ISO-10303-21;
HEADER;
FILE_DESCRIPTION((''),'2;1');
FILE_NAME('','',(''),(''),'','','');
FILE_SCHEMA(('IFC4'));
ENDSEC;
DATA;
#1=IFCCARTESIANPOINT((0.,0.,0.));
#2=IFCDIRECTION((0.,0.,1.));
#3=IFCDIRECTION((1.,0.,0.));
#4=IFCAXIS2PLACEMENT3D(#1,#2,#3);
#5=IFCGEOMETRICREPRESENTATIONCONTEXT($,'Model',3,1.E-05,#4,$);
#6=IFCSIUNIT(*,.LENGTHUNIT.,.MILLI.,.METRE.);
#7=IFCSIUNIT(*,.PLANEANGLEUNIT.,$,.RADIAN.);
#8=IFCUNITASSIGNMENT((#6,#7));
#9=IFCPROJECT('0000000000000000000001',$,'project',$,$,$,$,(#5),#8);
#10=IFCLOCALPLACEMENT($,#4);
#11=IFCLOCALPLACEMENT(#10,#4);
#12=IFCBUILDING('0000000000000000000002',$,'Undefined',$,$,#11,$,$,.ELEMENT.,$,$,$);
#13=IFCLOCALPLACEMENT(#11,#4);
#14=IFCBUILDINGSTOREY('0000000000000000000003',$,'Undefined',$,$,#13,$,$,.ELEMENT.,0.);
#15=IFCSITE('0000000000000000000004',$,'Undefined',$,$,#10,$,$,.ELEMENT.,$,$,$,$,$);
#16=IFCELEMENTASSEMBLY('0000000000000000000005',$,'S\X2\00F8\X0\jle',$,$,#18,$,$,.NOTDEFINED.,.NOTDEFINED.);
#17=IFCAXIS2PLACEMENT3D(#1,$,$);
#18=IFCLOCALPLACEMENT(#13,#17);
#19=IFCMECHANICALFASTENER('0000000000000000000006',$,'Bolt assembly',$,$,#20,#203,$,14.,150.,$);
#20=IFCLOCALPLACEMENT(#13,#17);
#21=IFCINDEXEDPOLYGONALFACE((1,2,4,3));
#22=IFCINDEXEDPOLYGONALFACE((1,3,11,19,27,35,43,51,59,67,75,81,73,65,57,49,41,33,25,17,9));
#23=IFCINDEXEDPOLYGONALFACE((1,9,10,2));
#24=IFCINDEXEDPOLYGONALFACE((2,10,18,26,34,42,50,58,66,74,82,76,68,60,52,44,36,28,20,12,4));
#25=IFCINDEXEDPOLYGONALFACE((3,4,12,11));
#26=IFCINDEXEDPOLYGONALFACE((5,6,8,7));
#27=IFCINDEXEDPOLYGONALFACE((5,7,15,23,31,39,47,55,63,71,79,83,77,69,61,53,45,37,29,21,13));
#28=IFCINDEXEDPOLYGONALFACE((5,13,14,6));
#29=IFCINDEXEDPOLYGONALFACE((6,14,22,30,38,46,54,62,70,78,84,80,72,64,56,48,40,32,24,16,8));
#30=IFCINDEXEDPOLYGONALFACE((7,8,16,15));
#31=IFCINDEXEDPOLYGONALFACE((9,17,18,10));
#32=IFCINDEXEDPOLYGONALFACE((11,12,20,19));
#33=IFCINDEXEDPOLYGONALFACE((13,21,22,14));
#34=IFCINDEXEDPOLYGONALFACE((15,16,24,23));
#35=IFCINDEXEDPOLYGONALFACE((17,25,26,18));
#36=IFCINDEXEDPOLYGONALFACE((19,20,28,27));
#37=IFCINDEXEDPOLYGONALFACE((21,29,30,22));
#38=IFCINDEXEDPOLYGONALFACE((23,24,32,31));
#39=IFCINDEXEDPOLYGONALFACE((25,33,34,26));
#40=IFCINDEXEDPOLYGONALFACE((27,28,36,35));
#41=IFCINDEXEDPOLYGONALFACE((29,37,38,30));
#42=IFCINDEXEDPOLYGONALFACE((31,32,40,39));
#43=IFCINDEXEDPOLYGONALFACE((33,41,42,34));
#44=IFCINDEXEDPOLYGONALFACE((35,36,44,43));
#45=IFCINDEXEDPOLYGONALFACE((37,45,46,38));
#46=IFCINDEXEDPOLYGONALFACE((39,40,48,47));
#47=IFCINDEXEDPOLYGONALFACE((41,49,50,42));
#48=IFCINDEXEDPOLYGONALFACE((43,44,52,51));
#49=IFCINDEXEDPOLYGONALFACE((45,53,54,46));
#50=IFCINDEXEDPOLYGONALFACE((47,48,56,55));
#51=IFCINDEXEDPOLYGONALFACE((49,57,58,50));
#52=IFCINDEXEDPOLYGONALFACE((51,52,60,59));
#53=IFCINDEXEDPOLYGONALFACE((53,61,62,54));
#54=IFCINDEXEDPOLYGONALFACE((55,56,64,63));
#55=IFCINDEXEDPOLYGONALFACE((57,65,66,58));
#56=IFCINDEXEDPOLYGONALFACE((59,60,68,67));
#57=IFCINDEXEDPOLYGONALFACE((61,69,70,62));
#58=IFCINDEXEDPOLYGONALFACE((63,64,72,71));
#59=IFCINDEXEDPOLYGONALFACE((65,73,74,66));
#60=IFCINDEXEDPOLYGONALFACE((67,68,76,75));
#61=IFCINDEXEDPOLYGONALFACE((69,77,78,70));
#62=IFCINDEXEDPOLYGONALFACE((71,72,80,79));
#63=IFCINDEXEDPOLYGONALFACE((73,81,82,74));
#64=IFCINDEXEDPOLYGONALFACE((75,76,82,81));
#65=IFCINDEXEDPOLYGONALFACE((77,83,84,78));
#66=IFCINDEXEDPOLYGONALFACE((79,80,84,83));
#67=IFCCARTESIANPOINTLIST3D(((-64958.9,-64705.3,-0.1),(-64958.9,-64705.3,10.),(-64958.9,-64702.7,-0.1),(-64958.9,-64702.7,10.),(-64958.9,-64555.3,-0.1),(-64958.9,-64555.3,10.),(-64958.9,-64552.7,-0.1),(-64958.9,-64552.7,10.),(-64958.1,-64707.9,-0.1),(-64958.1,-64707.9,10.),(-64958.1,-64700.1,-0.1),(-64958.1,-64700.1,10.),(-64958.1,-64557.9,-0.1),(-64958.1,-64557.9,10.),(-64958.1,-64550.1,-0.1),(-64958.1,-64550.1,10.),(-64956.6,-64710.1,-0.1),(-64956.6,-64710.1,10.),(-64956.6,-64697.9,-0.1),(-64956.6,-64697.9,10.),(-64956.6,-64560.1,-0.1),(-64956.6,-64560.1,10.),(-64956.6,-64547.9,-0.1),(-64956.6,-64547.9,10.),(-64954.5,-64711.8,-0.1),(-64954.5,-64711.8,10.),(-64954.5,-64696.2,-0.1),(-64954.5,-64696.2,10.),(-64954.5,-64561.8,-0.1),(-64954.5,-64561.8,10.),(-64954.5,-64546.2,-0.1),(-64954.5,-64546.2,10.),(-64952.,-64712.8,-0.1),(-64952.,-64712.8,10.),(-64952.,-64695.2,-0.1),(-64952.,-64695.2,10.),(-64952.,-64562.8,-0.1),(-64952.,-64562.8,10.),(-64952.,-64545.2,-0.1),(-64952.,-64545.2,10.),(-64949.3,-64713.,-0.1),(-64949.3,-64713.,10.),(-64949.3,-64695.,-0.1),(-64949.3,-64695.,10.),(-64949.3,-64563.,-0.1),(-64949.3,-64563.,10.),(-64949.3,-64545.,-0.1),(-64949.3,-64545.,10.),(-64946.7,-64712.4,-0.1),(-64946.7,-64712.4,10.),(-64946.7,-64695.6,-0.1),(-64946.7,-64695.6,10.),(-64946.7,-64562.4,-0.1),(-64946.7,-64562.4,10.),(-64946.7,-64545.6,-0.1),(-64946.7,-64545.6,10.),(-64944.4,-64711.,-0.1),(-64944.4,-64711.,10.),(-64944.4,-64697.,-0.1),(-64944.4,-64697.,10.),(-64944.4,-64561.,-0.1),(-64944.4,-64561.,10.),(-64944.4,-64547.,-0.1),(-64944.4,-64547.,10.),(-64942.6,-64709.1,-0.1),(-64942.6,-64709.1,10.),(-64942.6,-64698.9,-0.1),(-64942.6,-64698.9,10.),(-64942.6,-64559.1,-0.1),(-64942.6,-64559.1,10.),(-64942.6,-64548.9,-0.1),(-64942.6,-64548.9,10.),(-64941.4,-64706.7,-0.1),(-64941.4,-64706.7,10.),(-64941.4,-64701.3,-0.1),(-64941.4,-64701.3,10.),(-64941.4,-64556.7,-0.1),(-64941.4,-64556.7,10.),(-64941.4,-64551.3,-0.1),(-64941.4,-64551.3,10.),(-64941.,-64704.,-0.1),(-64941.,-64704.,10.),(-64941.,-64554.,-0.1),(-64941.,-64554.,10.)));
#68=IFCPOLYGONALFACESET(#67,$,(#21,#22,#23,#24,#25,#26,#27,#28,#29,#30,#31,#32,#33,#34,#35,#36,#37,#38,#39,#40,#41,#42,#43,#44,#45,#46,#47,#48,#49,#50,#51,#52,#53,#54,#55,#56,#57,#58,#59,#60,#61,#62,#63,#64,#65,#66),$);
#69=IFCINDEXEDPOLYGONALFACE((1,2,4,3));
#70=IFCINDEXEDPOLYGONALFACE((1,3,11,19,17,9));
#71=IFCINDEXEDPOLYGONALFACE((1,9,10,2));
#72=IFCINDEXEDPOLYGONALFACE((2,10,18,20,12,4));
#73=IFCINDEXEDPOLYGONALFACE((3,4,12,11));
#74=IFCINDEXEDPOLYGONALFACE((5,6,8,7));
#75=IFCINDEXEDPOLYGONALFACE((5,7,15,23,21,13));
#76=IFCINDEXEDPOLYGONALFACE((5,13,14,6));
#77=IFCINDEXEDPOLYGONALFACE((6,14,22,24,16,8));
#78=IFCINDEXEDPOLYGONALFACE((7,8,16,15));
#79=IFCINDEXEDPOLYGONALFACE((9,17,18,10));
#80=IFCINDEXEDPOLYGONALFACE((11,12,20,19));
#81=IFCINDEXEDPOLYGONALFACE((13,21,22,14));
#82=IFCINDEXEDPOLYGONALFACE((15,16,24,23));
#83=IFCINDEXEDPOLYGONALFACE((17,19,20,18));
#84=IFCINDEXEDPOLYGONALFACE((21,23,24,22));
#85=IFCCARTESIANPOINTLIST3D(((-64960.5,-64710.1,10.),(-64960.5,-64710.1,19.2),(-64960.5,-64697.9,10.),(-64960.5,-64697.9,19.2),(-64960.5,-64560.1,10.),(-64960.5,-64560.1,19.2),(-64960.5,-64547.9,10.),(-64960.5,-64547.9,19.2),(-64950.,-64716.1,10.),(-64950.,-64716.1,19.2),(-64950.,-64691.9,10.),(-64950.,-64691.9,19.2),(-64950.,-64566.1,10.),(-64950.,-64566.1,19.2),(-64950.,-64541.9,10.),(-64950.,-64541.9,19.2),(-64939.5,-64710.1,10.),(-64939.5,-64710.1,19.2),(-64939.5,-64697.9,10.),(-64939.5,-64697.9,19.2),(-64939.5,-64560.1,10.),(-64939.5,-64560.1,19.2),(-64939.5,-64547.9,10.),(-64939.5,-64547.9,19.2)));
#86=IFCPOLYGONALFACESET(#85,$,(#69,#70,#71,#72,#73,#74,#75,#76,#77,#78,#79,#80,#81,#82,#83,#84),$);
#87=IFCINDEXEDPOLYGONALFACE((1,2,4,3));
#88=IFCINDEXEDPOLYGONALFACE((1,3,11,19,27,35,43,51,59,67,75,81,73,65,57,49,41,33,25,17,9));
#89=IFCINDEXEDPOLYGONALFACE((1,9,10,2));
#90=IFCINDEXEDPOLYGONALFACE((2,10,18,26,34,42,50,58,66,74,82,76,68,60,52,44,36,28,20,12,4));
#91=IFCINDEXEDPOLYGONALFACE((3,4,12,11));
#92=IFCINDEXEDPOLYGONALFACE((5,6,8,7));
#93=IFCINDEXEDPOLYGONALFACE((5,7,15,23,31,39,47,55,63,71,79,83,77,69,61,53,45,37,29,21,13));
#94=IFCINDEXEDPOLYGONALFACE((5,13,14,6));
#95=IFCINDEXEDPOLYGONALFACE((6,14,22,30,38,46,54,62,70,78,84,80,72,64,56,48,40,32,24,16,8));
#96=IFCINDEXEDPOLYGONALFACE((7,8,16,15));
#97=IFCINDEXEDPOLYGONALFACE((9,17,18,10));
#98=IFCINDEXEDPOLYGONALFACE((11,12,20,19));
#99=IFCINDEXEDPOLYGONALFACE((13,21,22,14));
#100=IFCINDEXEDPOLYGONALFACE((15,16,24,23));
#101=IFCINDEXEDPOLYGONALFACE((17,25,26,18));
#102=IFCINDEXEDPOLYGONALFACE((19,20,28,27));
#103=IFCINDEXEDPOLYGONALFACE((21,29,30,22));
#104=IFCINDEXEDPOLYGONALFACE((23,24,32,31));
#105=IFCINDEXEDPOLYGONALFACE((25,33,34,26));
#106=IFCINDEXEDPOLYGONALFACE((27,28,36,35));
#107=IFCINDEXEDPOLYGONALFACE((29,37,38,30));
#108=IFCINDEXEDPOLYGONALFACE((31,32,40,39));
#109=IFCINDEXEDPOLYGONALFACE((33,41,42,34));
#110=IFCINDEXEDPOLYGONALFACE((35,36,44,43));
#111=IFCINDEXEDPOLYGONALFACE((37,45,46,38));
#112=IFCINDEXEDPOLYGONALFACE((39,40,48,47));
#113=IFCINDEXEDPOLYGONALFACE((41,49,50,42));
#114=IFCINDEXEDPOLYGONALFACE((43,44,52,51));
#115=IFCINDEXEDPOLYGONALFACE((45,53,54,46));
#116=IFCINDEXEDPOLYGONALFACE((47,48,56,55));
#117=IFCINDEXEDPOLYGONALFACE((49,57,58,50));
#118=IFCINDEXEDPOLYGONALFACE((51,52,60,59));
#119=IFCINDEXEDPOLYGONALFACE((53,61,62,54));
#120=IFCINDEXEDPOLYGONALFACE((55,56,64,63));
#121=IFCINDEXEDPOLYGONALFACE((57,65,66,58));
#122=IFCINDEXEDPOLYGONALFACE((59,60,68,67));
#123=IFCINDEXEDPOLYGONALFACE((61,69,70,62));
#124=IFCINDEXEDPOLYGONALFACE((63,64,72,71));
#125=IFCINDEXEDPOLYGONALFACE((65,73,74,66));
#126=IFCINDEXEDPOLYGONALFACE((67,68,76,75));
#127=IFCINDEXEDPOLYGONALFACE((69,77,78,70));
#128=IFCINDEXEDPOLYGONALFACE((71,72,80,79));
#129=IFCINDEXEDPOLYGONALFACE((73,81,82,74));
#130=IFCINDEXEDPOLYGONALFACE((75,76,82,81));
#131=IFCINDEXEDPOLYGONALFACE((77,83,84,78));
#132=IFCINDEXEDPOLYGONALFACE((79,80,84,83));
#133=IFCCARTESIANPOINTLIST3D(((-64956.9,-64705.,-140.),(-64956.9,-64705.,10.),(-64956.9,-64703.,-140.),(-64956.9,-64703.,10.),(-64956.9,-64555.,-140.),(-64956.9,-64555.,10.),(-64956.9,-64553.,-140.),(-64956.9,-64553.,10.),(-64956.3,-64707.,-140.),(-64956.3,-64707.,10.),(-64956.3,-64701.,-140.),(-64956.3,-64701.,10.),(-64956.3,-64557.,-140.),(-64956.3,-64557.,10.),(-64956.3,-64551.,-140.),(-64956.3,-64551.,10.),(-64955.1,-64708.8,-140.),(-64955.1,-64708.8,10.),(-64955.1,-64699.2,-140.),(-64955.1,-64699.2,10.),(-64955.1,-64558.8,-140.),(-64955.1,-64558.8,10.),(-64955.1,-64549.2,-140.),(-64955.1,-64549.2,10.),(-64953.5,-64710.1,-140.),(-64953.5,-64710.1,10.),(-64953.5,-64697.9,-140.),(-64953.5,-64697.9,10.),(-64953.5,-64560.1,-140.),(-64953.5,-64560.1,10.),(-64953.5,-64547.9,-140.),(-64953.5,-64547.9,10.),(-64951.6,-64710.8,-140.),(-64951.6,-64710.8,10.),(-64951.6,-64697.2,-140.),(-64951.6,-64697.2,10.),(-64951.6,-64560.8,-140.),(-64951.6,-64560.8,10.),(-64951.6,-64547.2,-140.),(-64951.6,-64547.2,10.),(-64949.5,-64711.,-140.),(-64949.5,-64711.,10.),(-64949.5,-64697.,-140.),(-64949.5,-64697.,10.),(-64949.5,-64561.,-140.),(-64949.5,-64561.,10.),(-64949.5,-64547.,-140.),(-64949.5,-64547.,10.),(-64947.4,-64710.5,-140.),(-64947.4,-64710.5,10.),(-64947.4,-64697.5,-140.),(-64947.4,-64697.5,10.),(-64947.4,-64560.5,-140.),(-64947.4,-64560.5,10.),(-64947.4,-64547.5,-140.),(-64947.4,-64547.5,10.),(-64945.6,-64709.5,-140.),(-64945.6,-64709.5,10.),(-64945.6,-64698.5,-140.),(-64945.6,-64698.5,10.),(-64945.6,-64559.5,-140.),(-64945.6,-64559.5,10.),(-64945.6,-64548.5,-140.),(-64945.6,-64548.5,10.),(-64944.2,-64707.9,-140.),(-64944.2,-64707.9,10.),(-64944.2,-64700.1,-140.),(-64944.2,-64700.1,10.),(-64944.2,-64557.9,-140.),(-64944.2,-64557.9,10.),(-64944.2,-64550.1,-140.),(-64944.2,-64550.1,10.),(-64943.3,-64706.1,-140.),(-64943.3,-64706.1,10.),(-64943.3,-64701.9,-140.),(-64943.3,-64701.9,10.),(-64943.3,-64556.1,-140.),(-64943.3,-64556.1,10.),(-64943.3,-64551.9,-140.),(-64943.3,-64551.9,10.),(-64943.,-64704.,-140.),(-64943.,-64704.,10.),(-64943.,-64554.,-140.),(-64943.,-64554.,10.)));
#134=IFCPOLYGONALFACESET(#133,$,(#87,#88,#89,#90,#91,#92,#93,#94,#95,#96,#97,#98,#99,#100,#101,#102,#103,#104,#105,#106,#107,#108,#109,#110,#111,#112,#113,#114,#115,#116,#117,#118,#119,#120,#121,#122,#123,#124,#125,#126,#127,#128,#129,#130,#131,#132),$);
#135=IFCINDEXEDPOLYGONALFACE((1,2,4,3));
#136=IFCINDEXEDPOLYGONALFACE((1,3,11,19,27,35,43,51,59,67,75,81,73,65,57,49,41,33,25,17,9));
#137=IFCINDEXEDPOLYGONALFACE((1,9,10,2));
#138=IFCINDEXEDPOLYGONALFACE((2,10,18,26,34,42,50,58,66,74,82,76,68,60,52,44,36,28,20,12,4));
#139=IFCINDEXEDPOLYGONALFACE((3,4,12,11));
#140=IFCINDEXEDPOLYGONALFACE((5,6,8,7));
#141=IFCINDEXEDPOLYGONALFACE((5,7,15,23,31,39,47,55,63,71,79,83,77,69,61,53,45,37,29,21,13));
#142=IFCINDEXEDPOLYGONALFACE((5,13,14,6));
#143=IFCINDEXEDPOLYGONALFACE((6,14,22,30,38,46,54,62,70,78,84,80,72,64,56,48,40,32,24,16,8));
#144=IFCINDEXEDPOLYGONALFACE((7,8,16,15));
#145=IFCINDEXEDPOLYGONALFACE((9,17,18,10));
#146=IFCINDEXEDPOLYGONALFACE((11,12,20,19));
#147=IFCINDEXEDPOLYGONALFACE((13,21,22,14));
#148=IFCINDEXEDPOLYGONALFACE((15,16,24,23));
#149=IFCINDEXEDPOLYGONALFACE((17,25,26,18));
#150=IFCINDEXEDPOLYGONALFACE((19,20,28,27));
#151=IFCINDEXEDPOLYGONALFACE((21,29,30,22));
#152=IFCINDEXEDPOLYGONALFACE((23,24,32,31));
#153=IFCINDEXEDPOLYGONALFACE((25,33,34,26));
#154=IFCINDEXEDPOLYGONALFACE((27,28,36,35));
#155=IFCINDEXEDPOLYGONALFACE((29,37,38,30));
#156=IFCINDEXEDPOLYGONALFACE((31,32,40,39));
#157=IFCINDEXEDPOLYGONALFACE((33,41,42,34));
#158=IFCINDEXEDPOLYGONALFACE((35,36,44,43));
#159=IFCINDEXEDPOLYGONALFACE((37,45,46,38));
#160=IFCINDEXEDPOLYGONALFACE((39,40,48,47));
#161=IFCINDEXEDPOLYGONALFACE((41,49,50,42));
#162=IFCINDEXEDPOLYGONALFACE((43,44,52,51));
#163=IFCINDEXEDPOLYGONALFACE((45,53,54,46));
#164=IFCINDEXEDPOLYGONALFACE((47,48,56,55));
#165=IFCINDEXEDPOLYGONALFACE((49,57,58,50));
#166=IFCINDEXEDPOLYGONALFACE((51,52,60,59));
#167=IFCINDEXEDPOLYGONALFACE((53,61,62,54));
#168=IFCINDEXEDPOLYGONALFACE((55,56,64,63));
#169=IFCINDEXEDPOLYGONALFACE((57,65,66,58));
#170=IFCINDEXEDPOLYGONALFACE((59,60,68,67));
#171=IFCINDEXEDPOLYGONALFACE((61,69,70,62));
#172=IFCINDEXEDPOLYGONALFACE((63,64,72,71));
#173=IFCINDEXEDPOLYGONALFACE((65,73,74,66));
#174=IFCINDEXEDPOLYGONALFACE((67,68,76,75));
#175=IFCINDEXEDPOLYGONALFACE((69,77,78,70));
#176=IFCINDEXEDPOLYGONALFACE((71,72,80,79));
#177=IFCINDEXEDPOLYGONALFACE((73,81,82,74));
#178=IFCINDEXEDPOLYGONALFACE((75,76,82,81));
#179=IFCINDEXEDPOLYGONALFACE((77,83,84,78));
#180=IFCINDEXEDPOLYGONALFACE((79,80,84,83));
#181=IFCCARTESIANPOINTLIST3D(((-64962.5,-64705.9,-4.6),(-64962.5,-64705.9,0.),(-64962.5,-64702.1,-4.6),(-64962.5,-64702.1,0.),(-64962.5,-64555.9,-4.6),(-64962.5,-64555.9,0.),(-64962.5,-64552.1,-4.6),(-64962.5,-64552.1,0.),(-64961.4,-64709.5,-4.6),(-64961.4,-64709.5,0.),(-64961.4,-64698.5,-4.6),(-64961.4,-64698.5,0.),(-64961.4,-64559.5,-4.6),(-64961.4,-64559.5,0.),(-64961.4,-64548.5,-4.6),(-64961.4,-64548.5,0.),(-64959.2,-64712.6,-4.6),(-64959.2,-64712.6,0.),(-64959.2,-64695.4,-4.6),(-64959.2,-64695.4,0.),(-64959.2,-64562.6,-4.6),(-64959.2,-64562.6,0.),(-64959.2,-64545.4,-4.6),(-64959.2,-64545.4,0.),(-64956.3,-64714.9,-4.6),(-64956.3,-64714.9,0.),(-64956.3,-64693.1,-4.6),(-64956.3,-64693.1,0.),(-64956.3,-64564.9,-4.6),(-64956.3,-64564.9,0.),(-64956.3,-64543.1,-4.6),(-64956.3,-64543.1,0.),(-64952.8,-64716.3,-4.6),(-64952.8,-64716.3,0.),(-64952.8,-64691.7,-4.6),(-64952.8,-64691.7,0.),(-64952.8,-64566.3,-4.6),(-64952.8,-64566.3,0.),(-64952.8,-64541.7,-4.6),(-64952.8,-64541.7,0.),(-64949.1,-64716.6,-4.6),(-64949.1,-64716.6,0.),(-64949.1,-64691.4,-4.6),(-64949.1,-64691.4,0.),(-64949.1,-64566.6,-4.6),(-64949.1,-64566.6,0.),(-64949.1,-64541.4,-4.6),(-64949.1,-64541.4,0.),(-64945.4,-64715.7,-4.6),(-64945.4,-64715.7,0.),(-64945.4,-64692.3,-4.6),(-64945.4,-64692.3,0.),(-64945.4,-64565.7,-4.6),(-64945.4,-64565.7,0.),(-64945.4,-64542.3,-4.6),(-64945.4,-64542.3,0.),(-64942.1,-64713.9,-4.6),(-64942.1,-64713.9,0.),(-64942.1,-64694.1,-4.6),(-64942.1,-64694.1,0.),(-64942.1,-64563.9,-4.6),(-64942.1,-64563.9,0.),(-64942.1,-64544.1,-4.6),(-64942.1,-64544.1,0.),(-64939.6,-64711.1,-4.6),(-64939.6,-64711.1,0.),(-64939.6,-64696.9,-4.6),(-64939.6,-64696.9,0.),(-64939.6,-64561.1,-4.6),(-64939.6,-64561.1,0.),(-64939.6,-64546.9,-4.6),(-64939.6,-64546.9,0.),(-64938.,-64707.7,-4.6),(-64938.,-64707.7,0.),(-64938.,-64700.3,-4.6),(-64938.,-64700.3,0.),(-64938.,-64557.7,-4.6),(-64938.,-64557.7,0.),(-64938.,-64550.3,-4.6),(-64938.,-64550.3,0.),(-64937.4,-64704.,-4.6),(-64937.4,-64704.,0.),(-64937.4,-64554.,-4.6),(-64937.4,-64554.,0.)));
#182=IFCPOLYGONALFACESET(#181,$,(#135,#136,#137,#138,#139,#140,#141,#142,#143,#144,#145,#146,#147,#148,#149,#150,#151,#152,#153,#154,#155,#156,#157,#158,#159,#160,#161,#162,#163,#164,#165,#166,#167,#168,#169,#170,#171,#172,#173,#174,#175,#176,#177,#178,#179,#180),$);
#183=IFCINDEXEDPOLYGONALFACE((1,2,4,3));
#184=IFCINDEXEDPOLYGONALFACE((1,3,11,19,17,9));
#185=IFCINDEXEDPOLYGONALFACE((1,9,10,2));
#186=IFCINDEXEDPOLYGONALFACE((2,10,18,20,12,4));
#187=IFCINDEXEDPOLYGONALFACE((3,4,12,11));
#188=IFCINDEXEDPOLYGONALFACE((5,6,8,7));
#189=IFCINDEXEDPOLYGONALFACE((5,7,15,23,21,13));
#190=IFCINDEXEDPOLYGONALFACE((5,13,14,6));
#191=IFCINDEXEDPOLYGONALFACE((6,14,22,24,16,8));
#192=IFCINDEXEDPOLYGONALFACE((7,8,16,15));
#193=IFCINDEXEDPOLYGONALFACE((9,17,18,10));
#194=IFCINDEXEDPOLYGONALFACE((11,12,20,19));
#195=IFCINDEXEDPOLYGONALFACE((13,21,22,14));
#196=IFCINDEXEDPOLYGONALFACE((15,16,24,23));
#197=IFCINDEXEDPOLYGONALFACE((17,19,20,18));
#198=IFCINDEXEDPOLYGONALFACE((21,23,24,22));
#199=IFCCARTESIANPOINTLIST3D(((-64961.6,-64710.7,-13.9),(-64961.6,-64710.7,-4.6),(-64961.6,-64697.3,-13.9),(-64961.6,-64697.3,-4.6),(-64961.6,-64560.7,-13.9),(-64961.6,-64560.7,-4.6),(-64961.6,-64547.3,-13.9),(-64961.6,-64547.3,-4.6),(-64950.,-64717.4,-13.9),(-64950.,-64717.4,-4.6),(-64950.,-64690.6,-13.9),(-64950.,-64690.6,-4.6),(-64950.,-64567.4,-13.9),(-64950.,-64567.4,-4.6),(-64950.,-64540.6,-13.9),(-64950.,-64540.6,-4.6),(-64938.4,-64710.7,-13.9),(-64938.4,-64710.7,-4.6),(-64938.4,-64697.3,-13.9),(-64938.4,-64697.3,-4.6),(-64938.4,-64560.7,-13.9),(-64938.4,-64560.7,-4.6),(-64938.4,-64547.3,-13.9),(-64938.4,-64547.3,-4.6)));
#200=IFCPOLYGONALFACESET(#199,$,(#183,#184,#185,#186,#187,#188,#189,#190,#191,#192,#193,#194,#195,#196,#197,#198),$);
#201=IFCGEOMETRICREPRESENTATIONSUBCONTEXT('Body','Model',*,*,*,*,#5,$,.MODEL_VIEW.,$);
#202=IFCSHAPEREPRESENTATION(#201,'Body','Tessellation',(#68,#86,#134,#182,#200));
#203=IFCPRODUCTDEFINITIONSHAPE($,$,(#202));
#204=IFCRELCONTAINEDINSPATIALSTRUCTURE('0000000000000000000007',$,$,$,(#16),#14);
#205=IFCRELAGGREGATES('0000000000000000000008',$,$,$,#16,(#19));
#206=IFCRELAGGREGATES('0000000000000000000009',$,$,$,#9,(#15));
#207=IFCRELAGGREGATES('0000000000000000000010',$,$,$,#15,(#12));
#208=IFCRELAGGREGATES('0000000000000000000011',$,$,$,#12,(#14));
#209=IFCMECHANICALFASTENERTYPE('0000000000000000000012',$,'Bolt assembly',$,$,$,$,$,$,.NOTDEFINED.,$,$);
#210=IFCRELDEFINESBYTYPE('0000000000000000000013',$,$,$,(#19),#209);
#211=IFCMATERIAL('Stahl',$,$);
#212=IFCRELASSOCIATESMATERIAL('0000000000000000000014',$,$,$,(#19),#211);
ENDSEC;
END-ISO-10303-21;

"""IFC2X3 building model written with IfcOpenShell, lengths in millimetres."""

from ifc_helpers import new_model, si_unit, frame, origin_with_axes, origin_2d_with_axis, place, context, subcontext, project, spatial, polyline, circle, outline, extrude, source, transform, mapped, material, type_object, element, aggregate, save


model = new_model("IFC2X3")

# Units and contexts
model_context = context("Model", 3, precision=1e-05, world=origin_with_axes())
body_context = subcontext(model_context, "Body", "Model", "MODEL_VIEW")
ifc_project = project(units=[si_unit("LENGTHUNIT", "METRE", prefix="MILLI"), si_unit("PLANEANGLEUNIT", "RADIAN")], contexts=[model_context])

# Site, building, storey
site_placement = place(None, origin_with_axes())
site = spatial("IfcSite", under=ifc_project, at=site_placement, Name="Undefined", CompositionType="ELEMENT")
building_placement = place(site_placement, origin_with_axes())
building = spatial("IfcBuilding", under=site, at=building_placement, Name="Undefined", CompositionType="ELEMENT")
storey_placement = place(building_placement, origin_with_axes())
storey = spatial("IfcBuildingStorey", under=building, at=storey_placement, Name="Undefined", CompositionType="ELEMENT", Elevation=0.0)

# Element assembly
assembly_1_placement = place(storey_placement, origin_with_axes())
assembly_1 = element("IfcElementAssembly", 1, at=assembly_1_placement, inside=storey, Name="Søjle", AssemblyPlace="NOTDEFINED", PredefinedType="NOTDEFINED")

# Mechanical fastener
mechanical_fastener_type = type_object("IfcMechanicalFastenerType", Name="Bolt assembly")
ifc_material_1 = material(Name="Stahl")
shared_shape_1 = source(origin_with_axes(), body_context, "Body", "SweptSolid", [
    extrude(circle(Radius=9.0, at=origin_2d_with_axis()), frame((0.0, 0.0, 0.0), z_axis=(0.0, 1.0, 0.0), x_axis=(1.0, 0.0, 0.0)), (0.0, 0.0, 1.0), 10.1),
    extrude(outline(polyline([(10.5, -6.1), (10.5, 6.1), (0.0, 12.1), (-10.5, 6.1), (-10.5, -6.1), (0.0, -12.1), (10.5, -6.1)])), frame((0.0, -9.2, 0.0), z_axis=(0.0, 1.0, 0.0), x_axis=(1.0, 0.0, 0.0)), (0.0, 0.0, 1.0), 9.2),
    extrude(circle(Radius=7.0, at=origin_2d_with_axis()), frame((0.0, 0.0, 0.0), z_axis=(0.0, 1.0, 0.0), x_axis=(1.0, 0.0, 0.0)), (0.0, 0.0, 1.0), 150.0),
    extrude(circle(Radius=12.6, at=origin_2d_with_axis()), frame((0.0, 10.0, 0.0), z_axis=(0.0, 1.0, 0.0), x_axis=(1.0, 0.0, 0.0)), (0.0, 0.0, 1.0), 4.6),
    extrude(outline(polyline([(11.6, -6.7), (11.6, 6.7), (0.0, 13.4), (-11.6, 6.7), (-11.6, -6.7), (0.0, -13.4), (11.6, -6.7)])), frame((0.0, 14.6, 0.0), z_axis=(0.0, 1.0, 0.0), x_axis=(1.0, 0.0, 0.0)), (0.0, 0.0, 1.0), 9.2),
])
mechanical_fastener_1_placement = place(assembly_1_placement, frame((-64950.0, -64629.0, 10.0), z_axis=(0.0, 1.0, 0.0), x_axis=(1.0, 0.0, 0.0)))
mechanical_fastener_1 = element("IfcMechanicalFastener", 2, at=mechanical_fastener_1_placement, type_object=mechanical_fastener_type, material=ifc_material_1, Name="Bolt assembly", NominalDiameter=14.0, NominalLength=150.0, context=body_context, shape_type="MappedRepresentation", body=[
    mapped(shared_shape_1, transform((0.0, 0.0, -75.0))),
    mapped(shared_shape_1, transform((0.0, 0.0, 75.0))),
])
aggregate(assembly_1, [mechanical_fastener_1])

save(model, "model.ifc")
